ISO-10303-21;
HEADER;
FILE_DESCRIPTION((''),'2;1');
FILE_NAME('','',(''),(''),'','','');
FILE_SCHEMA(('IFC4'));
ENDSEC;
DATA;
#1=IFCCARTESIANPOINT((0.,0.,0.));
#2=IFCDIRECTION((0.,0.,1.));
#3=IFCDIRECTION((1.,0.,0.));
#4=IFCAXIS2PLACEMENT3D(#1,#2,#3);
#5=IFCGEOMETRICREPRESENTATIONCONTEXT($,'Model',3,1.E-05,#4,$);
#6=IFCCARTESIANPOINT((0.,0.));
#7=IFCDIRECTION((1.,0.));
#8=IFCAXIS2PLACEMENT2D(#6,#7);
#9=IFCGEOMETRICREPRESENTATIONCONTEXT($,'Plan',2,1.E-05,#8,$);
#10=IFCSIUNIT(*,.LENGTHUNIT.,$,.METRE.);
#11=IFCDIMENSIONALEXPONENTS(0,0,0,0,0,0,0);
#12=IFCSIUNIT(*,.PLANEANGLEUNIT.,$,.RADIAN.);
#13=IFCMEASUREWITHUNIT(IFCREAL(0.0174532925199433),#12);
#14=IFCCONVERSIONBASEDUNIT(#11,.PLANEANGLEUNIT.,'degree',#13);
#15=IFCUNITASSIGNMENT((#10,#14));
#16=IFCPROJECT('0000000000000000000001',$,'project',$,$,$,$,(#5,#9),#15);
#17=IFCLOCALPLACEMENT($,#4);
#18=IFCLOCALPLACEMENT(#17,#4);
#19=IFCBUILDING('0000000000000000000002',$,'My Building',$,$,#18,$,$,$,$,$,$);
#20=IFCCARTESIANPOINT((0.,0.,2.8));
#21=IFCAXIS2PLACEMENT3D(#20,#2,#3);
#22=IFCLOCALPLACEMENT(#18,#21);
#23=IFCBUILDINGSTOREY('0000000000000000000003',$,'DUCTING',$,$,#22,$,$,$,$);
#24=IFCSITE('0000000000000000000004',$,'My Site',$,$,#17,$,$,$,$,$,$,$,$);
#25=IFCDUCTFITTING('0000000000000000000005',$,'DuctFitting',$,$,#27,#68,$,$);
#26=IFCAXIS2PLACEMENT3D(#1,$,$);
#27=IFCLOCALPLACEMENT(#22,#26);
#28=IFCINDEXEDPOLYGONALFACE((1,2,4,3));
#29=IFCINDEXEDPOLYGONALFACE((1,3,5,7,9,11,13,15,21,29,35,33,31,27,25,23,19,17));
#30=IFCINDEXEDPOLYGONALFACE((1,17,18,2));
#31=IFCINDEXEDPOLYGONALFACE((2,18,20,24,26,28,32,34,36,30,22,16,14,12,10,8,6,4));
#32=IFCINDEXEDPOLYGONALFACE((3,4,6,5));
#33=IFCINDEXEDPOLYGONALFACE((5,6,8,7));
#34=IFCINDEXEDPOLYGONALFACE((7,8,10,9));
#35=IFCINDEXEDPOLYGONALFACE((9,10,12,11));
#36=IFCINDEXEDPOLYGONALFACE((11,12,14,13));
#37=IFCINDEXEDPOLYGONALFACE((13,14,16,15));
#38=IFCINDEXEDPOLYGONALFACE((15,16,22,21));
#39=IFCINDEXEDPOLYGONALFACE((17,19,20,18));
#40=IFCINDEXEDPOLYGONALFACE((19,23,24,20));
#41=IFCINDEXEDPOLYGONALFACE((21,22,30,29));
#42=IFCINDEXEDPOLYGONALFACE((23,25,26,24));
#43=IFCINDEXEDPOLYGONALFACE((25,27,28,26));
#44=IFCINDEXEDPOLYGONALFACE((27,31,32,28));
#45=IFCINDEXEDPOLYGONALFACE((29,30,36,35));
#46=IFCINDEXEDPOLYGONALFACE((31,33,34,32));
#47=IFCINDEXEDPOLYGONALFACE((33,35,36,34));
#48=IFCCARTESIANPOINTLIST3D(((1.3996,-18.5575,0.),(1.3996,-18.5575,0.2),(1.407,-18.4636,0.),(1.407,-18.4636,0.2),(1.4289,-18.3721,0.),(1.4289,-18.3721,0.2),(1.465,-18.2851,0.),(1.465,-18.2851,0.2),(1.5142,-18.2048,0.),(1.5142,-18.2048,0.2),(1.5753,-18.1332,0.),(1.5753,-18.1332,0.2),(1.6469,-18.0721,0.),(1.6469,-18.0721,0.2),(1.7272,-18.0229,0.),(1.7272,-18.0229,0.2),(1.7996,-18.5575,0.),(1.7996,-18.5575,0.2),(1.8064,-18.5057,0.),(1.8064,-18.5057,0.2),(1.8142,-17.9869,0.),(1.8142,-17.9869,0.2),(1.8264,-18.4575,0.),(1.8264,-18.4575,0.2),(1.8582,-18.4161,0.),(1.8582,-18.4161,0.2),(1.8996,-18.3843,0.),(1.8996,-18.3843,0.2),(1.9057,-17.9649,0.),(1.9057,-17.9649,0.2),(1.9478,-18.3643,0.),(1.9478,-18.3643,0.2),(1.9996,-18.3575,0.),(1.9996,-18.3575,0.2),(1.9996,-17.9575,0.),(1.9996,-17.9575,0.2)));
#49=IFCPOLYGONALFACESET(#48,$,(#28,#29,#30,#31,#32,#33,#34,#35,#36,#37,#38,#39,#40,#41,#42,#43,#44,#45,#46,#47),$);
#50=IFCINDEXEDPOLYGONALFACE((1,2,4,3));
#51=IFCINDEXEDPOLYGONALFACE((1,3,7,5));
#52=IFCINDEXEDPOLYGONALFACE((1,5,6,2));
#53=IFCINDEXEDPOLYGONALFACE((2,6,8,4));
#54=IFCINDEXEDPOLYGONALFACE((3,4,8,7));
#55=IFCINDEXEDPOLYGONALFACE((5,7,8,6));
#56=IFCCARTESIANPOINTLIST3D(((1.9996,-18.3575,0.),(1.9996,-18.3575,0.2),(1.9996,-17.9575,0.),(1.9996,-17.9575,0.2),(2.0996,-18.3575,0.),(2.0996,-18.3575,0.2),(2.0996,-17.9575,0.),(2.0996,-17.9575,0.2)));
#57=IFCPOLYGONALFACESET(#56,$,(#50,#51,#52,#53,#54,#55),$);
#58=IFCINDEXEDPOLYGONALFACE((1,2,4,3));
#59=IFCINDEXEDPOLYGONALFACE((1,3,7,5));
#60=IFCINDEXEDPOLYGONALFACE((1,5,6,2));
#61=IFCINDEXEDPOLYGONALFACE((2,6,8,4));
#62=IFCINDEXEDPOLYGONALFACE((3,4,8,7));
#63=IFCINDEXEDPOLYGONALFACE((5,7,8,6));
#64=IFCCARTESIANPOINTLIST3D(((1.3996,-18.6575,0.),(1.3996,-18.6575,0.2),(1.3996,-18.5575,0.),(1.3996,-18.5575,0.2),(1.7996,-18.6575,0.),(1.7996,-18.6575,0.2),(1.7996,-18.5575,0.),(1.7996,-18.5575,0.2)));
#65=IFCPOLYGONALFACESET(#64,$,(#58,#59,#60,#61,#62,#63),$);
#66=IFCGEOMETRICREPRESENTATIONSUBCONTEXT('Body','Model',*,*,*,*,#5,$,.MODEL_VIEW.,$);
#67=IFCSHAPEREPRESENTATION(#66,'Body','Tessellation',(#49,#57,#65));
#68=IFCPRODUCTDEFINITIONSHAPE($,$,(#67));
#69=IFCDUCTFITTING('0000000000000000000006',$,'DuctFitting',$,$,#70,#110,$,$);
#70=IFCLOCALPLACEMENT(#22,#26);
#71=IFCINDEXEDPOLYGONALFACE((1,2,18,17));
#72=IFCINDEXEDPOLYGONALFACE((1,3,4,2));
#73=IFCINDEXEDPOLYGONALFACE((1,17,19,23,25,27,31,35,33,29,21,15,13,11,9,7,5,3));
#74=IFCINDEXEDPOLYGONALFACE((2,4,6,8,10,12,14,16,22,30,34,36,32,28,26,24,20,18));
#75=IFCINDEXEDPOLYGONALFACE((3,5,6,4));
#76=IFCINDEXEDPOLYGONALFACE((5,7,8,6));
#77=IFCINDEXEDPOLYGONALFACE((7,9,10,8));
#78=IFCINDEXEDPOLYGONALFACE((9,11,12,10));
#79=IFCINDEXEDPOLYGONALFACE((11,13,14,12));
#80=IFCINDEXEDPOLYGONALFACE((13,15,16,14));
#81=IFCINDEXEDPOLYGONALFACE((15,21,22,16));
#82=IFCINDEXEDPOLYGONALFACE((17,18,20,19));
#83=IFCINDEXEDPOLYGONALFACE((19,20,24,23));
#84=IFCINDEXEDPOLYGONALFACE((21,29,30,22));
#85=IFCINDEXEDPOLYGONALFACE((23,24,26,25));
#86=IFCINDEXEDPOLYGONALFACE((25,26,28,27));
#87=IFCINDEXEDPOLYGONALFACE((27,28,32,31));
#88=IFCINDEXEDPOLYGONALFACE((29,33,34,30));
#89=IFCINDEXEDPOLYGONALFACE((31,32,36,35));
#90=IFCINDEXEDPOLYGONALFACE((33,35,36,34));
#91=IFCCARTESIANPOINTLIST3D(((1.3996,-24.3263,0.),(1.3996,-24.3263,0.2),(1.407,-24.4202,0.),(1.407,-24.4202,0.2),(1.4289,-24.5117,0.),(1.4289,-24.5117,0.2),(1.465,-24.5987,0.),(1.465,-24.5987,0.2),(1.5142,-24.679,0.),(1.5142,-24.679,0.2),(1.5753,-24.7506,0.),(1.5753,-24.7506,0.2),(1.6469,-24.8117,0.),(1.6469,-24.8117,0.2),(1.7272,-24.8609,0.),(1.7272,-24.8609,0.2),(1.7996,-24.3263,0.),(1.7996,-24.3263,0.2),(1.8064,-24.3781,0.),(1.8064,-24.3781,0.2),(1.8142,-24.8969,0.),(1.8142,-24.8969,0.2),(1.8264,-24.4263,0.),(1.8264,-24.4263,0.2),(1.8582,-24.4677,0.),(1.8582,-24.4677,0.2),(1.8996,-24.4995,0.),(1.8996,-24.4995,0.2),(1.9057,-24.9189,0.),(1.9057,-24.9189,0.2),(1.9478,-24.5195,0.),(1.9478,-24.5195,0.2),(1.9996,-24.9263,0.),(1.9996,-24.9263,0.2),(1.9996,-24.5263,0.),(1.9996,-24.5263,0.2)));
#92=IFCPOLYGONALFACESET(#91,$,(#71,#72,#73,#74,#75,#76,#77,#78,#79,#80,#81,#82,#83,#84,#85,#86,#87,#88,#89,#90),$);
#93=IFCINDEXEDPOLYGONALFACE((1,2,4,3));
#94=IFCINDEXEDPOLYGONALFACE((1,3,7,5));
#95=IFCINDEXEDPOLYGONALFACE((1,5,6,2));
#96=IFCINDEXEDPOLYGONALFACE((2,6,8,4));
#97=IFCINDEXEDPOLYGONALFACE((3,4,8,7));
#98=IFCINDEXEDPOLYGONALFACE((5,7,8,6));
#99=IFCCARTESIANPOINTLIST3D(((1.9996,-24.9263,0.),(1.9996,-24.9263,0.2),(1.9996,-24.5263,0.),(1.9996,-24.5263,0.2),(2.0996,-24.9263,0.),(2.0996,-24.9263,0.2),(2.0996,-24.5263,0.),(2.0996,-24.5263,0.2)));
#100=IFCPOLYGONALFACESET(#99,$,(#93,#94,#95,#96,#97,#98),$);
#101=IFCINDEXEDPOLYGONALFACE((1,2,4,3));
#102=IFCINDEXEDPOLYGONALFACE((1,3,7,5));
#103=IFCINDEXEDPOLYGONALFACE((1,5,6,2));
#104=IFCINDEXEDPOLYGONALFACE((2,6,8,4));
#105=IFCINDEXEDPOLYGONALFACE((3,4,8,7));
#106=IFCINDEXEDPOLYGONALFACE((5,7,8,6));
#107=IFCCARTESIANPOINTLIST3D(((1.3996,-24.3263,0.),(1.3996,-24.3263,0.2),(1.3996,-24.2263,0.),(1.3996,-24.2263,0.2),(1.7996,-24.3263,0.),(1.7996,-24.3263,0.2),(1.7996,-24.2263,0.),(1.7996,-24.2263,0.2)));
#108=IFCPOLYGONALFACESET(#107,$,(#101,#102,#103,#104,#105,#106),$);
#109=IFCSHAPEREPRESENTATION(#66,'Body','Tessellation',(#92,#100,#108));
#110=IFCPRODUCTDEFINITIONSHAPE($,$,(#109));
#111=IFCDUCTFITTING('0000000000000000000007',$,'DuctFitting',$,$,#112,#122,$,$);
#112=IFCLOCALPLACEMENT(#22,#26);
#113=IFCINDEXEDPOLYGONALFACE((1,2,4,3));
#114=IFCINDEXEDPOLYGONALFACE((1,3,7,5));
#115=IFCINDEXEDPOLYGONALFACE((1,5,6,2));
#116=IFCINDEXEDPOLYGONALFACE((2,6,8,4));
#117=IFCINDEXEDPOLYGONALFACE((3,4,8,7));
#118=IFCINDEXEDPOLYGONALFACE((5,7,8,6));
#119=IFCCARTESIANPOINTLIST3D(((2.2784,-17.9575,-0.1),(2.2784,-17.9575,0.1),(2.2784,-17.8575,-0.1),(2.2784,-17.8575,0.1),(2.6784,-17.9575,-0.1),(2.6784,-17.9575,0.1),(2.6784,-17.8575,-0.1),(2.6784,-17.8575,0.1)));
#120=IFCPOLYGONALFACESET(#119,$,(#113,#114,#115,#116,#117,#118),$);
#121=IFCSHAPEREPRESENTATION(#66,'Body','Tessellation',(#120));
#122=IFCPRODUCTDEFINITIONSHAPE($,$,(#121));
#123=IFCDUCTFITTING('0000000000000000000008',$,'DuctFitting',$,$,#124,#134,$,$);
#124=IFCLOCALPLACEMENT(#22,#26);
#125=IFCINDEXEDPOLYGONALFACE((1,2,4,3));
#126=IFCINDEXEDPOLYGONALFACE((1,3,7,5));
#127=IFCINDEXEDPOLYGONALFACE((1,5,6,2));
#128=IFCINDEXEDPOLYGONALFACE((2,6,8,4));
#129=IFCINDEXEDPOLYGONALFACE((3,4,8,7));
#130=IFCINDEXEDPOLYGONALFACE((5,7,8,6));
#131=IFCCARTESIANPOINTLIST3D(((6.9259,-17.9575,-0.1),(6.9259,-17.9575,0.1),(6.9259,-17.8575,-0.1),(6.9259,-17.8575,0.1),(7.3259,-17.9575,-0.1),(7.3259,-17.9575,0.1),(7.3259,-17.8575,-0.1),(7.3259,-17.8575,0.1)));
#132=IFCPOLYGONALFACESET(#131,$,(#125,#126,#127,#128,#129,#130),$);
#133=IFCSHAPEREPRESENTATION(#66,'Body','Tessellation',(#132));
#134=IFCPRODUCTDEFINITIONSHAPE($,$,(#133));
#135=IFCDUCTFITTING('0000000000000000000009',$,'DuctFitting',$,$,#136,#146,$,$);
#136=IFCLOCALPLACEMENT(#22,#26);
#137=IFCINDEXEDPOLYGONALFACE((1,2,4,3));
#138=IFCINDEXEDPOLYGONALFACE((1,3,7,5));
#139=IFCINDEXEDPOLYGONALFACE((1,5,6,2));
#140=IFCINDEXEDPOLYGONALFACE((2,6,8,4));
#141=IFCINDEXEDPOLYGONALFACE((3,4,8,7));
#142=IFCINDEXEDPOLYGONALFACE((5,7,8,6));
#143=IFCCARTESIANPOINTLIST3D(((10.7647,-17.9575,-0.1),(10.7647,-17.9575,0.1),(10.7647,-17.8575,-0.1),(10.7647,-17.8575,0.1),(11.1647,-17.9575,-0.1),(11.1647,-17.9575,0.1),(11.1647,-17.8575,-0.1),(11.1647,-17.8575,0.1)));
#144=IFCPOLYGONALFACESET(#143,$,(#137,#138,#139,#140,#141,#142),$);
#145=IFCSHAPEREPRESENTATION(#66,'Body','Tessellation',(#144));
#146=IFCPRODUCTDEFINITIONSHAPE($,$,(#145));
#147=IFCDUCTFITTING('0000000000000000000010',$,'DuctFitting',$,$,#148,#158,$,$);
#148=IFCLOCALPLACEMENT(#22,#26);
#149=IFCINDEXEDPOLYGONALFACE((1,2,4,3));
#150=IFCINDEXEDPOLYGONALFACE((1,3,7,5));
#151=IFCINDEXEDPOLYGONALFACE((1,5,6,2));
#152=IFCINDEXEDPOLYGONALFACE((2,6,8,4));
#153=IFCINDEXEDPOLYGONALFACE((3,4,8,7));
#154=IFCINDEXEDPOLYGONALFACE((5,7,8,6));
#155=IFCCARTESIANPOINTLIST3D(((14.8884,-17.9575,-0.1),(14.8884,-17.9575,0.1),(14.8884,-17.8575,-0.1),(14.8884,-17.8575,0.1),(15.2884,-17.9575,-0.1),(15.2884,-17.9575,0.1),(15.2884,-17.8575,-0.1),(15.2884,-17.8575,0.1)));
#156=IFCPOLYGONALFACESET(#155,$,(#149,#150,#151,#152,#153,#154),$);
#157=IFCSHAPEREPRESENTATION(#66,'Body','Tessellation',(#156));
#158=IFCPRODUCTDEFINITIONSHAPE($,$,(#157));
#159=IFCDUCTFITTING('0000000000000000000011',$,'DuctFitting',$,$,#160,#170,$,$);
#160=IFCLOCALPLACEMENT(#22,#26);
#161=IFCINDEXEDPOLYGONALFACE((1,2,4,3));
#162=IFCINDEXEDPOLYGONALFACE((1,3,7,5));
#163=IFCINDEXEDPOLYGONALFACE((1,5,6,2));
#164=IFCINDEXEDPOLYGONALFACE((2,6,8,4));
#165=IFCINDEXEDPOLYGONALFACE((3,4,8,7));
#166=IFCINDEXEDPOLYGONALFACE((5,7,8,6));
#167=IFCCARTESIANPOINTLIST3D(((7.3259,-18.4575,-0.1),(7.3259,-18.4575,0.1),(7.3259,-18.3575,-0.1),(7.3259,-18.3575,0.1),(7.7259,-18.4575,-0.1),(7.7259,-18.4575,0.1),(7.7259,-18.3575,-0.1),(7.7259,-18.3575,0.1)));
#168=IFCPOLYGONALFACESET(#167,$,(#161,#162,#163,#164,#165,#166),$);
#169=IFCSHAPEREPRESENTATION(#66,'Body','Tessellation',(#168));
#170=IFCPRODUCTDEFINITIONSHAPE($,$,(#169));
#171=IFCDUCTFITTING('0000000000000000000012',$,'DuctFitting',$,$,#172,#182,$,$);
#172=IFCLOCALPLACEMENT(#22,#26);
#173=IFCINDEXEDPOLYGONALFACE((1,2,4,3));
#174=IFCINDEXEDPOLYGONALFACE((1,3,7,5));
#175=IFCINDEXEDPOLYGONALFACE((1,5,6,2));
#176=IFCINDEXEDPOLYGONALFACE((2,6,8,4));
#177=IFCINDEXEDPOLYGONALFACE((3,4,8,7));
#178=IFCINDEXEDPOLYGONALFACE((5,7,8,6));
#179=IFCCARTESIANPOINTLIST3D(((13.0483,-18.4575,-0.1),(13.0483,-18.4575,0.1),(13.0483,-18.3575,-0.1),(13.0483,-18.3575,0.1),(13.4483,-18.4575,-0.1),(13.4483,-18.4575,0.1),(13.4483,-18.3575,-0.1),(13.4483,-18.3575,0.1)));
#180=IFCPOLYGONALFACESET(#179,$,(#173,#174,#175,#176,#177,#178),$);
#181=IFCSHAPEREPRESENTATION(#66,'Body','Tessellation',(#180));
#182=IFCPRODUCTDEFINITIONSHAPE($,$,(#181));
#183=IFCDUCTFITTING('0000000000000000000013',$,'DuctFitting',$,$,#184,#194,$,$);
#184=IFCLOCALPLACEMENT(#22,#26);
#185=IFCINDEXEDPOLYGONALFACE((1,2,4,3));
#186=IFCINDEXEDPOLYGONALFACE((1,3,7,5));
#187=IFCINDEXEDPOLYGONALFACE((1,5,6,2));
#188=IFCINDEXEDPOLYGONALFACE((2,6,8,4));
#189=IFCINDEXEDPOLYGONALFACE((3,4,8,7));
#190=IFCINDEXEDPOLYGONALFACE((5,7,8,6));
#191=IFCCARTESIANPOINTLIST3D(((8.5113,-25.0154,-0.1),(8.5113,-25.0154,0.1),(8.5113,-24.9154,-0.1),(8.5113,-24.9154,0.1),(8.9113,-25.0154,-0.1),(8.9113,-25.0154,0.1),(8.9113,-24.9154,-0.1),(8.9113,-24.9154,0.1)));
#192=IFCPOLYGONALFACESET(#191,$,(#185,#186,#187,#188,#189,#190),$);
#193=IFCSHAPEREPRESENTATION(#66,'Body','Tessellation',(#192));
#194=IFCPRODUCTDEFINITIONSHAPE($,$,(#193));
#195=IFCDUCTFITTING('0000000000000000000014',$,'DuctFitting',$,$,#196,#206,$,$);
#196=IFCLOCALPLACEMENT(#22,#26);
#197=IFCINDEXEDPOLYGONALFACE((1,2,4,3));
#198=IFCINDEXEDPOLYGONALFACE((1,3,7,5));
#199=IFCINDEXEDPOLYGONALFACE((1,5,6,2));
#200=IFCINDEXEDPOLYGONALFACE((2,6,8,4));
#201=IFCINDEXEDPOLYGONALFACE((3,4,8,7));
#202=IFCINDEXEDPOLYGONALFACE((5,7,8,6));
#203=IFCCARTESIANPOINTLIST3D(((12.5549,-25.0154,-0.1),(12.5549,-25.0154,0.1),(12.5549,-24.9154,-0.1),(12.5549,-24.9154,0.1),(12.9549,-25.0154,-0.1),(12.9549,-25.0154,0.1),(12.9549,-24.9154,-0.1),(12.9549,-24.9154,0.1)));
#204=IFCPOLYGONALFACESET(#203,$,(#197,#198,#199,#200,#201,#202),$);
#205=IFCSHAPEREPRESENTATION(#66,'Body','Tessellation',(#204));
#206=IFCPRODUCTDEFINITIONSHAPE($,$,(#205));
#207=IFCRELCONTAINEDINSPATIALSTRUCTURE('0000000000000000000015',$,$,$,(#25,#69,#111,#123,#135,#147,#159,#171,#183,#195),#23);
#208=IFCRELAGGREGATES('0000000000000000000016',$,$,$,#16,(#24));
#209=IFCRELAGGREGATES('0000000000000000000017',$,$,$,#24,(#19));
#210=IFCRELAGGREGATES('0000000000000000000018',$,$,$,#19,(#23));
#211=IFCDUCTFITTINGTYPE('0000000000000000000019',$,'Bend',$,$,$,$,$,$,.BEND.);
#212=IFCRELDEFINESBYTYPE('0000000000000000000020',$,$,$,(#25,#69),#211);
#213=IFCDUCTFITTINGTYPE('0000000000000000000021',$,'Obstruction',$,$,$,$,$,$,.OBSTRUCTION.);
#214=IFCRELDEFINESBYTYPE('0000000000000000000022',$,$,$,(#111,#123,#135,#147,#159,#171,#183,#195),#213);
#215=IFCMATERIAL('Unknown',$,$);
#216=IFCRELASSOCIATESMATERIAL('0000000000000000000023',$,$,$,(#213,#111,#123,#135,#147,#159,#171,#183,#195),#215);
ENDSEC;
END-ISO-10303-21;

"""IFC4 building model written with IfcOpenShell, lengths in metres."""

from ifc_helpers import new_model, entity, si_unit, converted_unit, frame, origin_with_axes, origin_2d_with_axis, place, context, subcontext, project, spatial, line, arc, indexed_curve, rectangle, outline, extrude, source, transform, mapped, material, material_profile, profile_set, profile_usage, type_object, type_shapes, element, save


model = new_model("IFC4")

# Units and contexts
model_context = context("Model", 3, precision=1e-05, world=origin_with_axes())
plan_context = context("Plan", 2, precision=1e-05, world=origin_2d_with_axis())
body_context = subcontext(model_context, "Body", "Model", "MODEL_VIEW")
ifc_project = project(units=[si_unit("LENGTHUNIT", "METRE"), converted_unit("PLANEANGLEUNIT", "degree", entity("IfcReal", 0.0174532925199433), si_unit("PLANEANGLEUNIT", "RADIAN"), dimensions=[0, 0, 0, 0, 0, 0, 0])], contexts=[model_context, plan_context])

# Site, building, storey
site_placement = place(None, origin_with_axes())
site = spatial("IfcSite", under=ifc_project, at=site_placement, Name="My Site")
building_placement = place(site_placement, origin_with_axes())
building = spatial("IfcBuilding", under=site, at=building_placement, Name="My Building")
storey_placement = place(building_placement, frame((0.0, 0.0, 2.8), z_axis=(0.0, 0.0, 1.0), x_axis=(1.0, 0.0, 0.0)))
storey = spatial("IfcBuildingStorey", under=building, at=storey_placement, Name="DUCTING")

# Shared definitions
ifc_material = material(Name="Unknown")

# Duct fittings
duct_fitting_type_1 = type_object("IfcDuctFittingType", Name="Bend", PredefinedType="BEND")
shared_shape = source(origin_with_axes(), body_context, "Body", "SweptSolid", [
    extrude(outline(indexed_curve([(-0.2, 0.0), (-0.2586, -0.1414), (-0.4, -0.2), (-0.4, -0.6), (0.0243, -0.4243), (0.2, 0.0)], segments=[arc(1, 2, 3), line(3, 4), arc(4, 5, 6), line(6, 1)])), frame((0.0, -0.1, -0.1), z_axis=(0.0, -1.0, 0.0), x_axis=(1.0, 0.0, 0.0)), (0.0, 0.0, -1.0), 0.2),
    extrude(rectangle(XDim=0.4, YDim=0.2), origin_with_axes(), (0.0, 0.0, -1.0), 0.1),
    extrude(rectangle(XDim=0.4, YDim=0.2), frame((-0.4, 0.0, -0.5), z_axis=(-1.0, 0.0, 0.0), x_axis=(0.0, 0.0, -1.0)), (0.0, 0.0, 1.0), 0.1),
])
type_shapes(duct_fitting_type_1, [shared_shape])
for number, where, z_axis, x_axis, name in (
    (1, (2.0996, -18.1575, 0.1), (1.0, 0.0, 0.0), (0.0, 1.0, 0.0), "DuctFitting"),
    (2, (2.0996, -24.7263, 0.1), (1.0, 0.0, 0.0), (0.0, -1.0, 0.0), "DuctFitting"),
):
    element("IfcDuctFitting", number, at=place(storey_placement, frame(where, z_axis=z_axis, x_axis=x_axis)), inside=storey, type_object=duct_fitting_type_1, Name=name, context=body_context, shape_type="MappedRepresentation", body=[
        mapped(shared_shape, transform((0.0, 0.0, 0.0), x_axis=(1.0, 0.0, 0.0), y_axis=(0.0, 1.0, 0.0), z_axis=(0.0, 0.0, 1.0), scale=1.0)),
    ])
ifc_material_profile_1 = material_profile(ifc_material, rectangle(XDim=0.4, YDim=0.2))
ifc_profile_set_1 = profile_set([ifc_material_profile_1])
ifc_profile_usage_1 = profile_usage(ifc_profile_set_1, cardinal=5)
duct_fitting_type_2 = type_object("IfcDuctFittingType", Name="Obstruction", PredefinedType="OBSTRUCTION", material=ifc_profile_set_1)
duct_fitting_1_placement = place(storey_placement, frame((2.4784, -17.9575, 0.0), z_axis=(0.0, 1.0, 0.0), x_axis=(-1.0, 0.0, 0.0)))
element("IfcDuctFitting", 3, at=duct_fitting_1_placement, inside=storey, type_object=duct_fitting_type_2, material=ifc_profile_usage_1, Name="DuctFitting", context=body_context, shape_type="SweptSolid", body=[
    extrude(rectangle(XDim=0.4, YDim=0.2), origin_with_axes(), (0.0, 0.0, 1.0), 0.1),
])
ifc_profile_usage_2 = profile_usage(ifc_profile_set_1, cardinal=5)
duct_fitting_2_placement = place(storey_placement, frame((7.1259, -17.9575, 0.0), z_axis=(0.0, 1.0, 0.0), x_axis=(-1.0, 0.0, 0.0)))
element("IfcDuctFitting", 4, at=duct_fitting_2_placement, inside=storey, type_object=duct_fitting_type_2, material=ifc_profile_usage_2, Name="DuctFitting", context=body_context, shape_type="SweptSolid", body=[
    extrude(rectangle(XDim=0.4, YDim=0.2), origin_with_axes(), (0.0, 0.0, 1.0), 0.1),
])
ifc_profile_usage_3 = profile_usage(ifc_profile_set_1, cardinal=5)
duct_fitting_3_placement = place(storey_placement, frame((10.9647, -17.9575, 0.0), z_axis=(0.0, 1.0, 0.0), x_axis=(-1.0, 0.0, 0.0)))
element("IfcDuctFitting", 5, at=duct_fitting_3_placement, inside=storey, type_object=duct_fitting_type_2, material=ifc_profile_usage_3, Name="DuctFitting", context=body_context, shape_type="SweptSolid", body=[
    extrude(rectangle(XDim=0.4, YDim=0.2), origin_with_axes(), (0.0, 0.0, 1.0), 0.1),
])
ifc_profile_usage_4 = profile_usage(ifc_profile_set_1, cardinal=5)
duct_fitting_4_placement = place(storey_placement, frame((15.0884, -17.9575, 0.0), z_axis=(0.0, 1.0, 0.0), x_axis=(-1.0, 0.0, 0.0)))
element("IfcDuctFitting", 6, at=duct_fitting_4_placement, inside=storey, type_object=duct_fitting_type_2, material=ifc_profile_usage_4, Name="DuctFitting", context=body_context, shape_type="SweptSolid", body=[
    extrude(rectangle(XDim=0.4, YDim=0.2), origin_with_axes(), (0.0, 0.0, 1.0), 0.1),
])
ifc_profile_usage_5 = profile_usage(ifc_profile_set_1, cardinal=5)
duct_fitting_5_placement = place(storey_placement, frame((7.5259, -18.3575, 0.0), z_axis=(0.0, -1.0, 0.0), x_axis=(1.0, 0.0, 0.0)))
element("IfcDuctFitting", 7, at=duct_fitting_5_placement, inside=storey, type_object=duct_fitting_type_2, material=ifc_profile_usage_5, Name="DuctFitting", context=body_context, shape_type="SweptSolid", body=[
    extrude(rectangle(XDim=0.4, YDim=0.2), origin_with_axes(), (0.0, 0.0, 1.0), 0.1),
])
ifc_profile_usage_6 = profile_usage(ifc_profile_set_1, cardinal=5)
duct_fitting_6_placement = place(storey_placement, frame((13.2483, -18.3575, 0.0), z_axis=(0.0, -1.0, 0.0), x_axis=(1.0, 0.0, 0.0)))
element("IfcDuctFitting", 8, at=duct_fitting_6_placement, inside=storey, type_object=duct_fitting_type_2, material=ifc_profile_usage_6, Name="DuctFitting", context=body_context, shape_type="SweptSolid", body=[
    extrude(rectangle(XDim=0.4, YDim=0.2), origin_with_axes(), (0.0, 0.0, 1.0), 0.1),
])
ifc_profile_usage_7 = profile_usage(ifc_profile_set_1, cardinal=5)
duct_fitting_7_placement = place(storey_placement, frame((8.7113, -24.9154, 0.0), z_axis=(0.0, -1.0, 0.0), x_axis=(1.0, 0.0, 0.0)))
element("IfcDuctFitting", 9, at=duct_fitting_7_placement, inside=storey, type_object=duct_fitting_type_2, material=ifc_profile_usage_7, Name="DuctFitting", context=body_context, shape_type="SweptSolid", body=[
    extrude(rectangle(XDim=0.4, YDim=0.2), origin_with_axes(), (0.0, 0.0, 1.0), 0.1),
])
ifc_profile_usage_8 = profile_usage(ifc_profile_set_1, cardinal=5)
duct_fitting_8_placement = place(storey_placement, frame((12.7549, -24.9154, 0.0), z_axis=(0.0, -1.0, 0.0), x_axis=(1.0, 0.0, 0.0)))
element("IfcDuctFitting", 10, at=duct_fitting_8_placement, inside=storey, type_object=duct_fitting_type_2, material=ifc_profile_usage_8, Name="DuctFitting", context=body_context, shape_type="SweptSolid", body=[
    extrude(rectangle(XDim=0.4, YDim=0.2), origin_with_axes(), (0.0, 0.0, 1.0), 0.1),
])

save(model, "model.ifc")
